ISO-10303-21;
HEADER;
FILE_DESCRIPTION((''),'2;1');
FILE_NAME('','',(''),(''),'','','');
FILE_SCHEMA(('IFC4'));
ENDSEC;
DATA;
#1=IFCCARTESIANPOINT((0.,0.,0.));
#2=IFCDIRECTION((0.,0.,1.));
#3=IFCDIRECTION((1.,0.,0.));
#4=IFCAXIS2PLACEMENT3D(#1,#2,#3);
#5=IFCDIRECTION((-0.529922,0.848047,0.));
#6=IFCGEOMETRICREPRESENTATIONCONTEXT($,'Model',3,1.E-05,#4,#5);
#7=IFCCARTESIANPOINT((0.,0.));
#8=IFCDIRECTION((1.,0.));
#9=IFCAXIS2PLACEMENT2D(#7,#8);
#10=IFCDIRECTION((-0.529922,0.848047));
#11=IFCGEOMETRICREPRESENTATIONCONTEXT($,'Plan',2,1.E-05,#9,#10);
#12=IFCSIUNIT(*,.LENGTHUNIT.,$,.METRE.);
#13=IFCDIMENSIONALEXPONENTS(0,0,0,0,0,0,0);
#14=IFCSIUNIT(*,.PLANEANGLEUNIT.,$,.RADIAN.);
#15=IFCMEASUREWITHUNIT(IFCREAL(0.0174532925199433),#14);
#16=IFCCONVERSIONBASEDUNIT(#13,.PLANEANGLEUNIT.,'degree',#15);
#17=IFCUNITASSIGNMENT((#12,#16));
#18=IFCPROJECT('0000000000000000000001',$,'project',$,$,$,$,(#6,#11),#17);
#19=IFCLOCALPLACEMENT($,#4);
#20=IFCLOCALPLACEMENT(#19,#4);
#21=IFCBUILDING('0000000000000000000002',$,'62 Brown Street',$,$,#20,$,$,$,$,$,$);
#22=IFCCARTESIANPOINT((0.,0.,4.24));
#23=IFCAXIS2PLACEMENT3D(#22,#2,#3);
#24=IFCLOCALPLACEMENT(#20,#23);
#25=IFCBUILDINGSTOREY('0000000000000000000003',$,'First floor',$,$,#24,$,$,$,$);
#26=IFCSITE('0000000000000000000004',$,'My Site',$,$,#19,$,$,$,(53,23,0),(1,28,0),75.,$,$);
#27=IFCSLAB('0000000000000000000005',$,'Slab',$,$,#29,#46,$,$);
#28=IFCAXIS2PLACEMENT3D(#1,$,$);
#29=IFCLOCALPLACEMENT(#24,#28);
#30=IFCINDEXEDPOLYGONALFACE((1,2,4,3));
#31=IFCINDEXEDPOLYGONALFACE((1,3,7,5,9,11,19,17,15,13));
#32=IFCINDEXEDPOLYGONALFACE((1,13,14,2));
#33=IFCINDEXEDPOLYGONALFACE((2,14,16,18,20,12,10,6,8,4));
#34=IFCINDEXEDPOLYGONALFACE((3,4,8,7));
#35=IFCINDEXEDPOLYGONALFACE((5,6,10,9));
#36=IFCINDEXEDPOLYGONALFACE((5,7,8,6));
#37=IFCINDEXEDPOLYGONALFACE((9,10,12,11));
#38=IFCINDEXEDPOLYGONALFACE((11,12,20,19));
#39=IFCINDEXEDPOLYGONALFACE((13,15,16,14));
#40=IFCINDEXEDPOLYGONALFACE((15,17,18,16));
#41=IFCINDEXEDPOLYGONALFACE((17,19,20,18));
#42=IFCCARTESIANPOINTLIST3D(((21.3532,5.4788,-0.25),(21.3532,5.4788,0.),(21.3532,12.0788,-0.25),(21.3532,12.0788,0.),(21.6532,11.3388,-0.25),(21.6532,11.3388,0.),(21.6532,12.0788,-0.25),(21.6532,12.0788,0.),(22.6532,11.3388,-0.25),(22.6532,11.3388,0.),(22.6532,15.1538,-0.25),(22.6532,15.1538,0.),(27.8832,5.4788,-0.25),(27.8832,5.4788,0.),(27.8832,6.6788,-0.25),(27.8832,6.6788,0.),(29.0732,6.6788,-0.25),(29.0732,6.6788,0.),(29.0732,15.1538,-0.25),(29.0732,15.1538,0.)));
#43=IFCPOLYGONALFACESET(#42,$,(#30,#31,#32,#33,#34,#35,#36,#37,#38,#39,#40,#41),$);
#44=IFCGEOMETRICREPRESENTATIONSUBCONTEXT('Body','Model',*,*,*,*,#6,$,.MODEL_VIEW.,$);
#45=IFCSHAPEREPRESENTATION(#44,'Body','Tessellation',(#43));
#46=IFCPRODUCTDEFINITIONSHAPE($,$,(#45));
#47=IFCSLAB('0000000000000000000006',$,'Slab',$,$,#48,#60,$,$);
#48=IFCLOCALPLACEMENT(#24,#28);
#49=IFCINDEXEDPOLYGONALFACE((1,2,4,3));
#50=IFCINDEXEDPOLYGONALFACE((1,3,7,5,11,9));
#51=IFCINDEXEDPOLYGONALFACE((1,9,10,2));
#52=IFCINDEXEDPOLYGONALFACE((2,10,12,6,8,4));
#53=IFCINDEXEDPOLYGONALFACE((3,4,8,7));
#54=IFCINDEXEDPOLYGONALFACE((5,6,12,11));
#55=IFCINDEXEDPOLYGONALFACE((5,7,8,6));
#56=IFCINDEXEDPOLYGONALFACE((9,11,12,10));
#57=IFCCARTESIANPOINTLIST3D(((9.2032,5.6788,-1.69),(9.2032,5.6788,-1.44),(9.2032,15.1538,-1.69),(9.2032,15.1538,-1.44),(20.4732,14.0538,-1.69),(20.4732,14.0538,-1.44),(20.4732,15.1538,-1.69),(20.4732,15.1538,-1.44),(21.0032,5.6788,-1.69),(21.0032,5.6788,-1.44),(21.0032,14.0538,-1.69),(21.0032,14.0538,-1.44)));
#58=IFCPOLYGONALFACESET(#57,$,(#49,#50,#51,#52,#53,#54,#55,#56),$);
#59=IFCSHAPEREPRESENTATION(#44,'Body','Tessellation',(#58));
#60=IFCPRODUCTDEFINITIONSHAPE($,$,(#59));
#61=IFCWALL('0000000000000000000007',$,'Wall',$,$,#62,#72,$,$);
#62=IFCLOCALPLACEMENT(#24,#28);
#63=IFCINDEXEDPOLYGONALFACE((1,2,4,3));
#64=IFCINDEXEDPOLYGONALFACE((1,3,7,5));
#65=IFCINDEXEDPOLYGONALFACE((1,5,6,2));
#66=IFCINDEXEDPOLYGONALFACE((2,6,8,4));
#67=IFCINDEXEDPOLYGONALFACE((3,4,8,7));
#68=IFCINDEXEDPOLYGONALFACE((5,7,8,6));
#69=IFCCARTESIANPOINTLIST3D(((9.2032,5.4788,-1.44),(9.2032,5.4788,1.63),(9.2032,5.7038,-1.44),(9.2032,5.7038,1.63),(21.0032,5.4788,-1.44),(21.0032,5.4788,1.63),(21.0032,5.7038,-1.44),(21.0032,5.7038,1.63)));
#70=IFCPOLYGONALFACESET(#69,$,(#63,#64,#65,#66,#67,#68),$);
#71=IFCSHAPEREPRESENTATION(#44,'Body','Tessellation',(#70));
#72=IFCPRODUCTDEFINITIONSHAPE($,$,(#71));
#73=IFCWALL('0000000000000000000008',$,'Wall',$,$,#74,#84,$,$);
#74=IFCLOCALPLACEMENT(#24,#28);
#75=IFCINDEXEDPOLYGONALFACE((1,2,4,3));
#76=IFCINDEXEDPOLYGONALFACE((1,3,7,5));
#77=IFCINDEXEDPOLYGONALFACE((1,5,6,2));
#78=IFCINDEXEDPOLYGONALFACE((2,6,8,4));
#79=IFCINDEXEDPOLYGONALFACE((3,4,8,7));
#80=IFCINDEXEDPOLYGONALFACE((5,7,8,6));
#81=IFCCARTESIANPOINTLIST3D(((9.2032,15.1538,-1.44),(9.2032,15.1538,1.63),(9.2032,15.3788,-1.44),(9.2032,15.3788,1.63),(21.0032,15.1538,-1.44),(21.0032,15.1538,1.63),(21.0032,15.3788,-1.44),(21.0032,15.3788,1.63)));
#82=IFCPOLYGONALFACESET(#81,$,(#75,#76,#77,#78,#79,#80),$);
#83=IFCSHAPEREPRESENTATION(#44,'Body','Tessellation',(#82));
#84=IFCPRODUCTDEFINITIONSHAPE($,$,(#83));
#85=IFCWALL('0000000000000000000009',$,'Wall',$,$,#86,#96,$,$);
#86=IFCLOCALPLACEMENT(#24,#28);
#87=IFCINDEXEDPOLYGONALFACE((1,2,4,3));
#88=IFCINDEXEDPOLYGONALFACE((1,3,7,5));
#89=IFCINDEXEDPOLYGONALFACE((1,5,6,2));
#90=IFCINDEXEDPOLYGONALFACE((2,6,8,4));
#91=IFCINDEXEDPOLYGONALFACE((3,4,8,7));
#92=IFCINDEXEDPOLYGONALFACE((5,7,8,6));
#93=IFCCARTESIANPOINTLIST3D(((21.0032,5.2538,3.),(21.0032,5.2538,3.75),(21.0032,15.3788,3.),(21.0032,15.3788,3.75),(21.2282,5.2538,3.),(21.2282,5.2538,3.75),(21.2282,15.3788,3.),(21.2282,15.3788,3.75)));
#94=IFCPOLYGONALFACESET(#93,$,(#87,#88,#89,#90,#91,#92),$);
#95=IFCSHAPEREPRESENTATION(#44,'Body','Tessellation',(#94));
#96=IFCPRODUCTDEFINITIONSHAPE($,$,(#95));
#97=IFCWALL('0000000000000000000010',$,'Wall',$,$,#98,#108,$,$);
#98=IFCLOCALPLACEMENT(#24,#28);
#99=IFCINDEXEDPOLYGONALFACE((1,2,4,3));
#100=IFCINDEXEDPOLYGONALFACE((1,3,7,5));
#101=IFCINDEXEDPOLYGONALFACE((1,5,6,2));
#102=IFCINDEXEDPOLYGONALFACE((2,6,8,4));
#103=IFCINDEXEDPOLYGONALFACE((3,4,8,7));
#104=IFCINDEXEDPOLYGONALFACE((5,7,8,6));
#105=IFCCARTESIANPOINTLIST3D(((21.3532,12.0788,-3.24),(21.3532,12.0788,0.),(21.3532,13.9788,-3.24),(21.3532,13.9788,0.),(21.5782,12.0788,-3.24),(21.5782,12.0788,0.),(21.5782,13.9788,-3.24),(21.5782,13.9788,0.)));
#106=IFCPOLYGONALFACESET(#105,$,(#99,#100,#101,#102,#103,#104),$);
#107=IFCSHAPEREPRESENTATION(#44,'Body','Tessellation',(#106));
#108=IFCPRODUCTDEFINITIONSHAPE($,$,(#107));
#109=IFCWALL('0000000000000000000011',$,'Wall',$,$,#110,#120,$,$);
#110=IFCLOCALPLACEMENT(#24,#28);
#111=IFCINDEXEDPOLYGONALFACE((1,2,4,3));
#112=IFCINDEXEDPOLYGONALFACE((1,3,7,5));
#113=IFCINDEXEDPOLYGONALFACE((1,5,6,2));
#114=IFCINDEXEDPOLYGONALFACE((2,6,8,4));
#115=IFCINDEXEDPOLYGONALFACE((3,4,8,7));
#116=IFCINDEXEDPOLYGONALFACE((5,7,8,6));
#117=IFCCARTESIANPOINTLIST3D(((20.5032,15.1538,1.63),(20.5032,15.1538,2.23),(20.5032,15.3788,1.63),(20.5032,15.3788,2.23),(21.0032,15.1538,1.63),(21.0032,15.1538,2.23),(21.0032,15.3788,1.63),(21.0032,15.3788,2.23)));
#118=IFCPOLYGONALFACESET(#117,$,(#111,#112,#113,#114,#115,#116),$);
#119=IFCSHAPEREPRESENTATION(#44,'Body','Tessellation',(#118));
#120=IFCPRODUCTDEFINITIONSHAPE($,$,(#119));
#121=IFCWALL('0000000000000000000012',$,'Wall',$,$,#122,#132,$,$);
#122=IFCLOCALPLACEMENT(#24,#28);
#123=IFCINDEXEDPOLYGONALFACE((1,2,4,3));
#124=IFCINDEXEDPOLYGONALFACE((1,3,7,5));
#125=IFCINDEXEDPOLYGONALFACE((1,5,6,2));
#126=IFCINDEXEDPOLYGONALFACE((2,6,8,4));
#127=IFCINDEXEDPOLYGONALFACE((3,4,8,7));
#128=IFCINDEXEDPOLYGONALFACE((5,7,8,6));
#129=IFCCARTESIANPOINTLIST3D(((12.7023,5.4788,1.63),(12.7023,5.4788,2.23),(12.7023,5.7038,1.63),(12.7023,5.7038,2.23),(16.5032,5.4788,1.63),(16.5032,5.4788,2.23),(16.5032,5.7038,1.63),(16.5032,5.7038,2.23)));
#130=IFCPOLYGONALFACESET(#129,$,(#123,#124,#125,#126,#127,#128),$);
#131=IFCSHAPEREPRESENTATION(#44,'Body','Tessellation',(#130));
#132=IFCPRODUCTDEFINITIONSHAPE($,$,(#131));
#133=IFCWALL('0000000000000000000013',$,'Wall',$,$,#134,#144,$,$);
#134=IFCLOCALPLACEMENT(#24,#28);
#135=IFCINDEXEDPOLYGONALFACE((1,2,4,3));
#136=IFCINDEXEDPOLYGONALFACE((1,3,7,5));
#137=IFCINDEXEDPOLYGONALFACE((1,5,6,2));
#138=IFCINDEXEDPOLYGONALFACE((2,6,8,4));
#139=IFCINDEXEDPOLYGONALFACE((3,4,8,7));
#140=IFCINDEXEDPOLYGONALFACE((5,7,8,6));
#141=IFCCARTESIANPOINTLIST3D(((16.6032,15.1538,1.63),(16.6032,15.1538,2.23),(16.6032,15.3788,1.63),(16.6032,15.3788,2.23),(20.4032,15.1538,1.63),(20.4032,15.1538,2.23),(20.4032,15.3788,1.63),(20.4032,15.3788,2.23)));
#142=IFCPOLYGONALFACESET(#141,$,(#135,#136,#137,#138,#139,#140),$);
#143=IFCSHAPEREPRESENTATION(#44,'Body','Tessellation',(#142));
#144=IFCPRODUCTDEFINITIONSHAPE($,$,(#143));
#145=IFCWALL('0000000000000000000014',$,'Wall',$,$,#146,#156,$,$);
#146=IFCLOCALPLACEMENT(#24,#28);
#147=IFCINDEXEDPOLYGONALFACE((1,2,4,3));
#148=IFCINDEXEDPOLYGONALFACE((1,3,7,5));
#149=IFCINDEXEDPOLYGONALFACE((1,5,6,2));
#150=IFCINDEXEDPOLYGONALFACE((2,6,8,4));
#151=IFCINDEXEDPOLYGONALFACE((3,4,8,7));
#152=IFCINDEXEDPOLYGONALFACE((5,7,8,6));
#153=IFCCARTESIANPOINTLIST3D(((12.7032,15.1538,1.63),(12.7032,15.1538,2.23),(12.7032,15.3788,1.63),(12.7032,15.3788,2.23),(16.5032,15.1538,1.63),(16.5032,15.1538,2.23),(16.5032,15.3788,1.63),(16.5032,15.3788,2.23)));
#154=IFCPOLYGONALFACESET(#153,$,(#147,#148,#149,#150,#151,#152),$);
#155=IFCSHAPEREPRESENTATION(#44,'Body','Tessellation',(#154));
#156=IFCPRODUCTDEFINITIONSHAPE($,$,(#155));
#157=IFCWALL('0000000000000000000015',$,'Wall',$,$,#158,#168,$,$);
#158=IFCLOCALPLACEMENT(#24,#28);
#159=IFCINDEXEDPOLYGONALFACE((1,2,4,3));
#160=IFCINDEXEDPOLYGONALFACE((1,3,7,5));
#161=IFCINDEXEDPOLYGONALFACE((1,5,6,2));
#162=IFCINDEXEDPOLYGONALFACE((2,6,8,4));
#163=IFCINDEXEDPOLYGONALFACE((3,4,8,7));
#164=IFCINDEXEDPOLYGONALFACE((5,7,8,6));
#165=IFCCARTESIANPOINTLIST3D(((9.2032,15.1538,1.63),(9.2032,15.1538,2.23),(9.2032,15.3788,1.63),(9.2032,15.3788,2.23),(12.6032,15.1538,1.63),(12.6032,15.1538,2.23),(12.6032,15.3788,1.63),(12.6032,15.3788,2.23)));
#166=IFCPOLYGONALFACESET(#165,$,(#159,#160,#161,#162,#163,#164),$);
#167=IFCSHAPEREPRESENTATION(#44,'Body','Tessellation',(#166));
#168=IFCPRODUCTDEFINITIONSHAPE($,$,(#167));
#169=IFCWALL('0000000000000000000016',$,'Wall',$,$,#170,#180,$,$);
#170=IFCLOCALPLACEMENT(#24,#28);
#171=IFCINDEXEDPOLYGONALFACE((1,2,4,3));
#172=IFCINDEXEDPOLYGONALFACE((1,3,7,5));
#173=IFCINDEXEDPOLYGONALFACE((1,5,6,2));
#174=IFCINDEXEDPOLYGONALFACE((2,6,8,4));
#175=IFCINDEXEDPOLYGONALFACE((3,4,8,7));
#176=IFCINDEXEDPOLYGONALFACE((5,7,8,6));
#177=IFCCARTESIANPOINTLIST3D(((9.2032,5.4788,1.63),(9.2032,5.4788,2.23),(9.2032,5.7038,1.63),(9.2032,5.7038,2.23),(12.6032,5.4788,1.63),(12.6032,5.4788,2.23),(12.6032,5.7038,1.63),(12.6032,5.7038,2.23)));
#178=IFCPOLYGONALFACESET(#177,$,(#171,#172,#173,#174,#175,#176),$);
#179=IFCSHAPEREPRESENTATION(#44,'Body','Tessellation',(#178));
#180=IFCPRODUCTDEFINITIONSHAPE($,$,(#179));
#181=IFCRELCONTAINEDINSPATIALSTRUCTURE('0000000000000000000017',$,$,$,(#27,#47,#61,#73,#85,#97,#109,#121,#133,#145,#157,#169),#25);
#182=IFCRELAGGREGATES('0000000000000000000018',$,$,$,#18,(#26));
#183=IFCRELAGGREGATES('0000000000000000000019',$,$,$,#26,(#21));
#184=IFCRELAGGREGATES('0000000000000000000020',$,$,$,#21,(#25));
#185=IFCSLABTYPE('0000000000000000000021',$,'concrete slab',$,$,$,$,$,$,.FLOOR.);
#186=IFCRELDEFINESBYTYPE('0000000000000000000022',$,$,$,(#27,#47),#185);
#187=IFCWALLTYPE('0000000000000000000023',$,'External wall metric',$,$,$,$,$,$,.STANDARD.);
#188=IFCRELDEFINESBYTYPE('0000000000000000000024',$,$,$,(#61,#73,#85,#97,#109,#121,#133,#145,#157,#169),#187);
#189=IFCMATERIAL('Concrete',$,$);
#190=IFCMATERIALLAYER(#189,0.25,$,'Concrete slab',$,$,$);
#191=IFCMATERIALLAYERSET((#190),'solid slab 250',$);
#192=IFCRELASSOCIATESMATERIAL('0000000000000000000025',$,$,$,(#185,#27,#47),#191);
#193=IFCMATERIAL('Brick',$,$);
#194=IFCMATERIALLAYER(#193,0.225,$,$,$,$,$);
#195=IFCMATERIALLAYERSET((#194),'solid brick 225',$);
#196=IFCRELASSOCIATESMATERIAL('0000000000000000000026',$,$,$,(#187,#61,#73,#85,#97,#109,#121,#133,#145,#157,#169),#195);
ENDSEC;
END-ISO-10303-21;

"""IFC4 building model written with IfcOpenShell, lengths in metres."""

from ifc_helpers import new_model, entity, si_unit, converted_unit, direction, frame, origin_with_axes, origin_2d_with_axis, place, context, subcontext, project, spatial, line, indexed_curve, outline, extrude, material, layer, layer_set, layer_usage, type_object, element, save


model = new_model("IFC4")

# Units and contexts
model_context = context("Model", 3, precision=1e-05, world=origin_with_axes(), true_north=direction((-0.529922, 0.848047, 0.0)))
plan_context = context("Plan", 2, precision=1e-05, world=origin_2d_with_axis(), true_north=direction((-0.529922, 0.848047)))
body_context_1 = subcontext(model_context, "Body", "Model", "MODEL_VIEW")
ifc_project = project(units=[si_unit("LENGTHUNIT", "METRE"), converted_unit("PLANEANGLEUNIT", "degree", entity("IfcReal", 0.0174532925199433), si_unit("PLANEANGLEUNIT", "RADIAN"), dimensions=[0, 0, 0, 0, 0, 0, 0])], contexts=[model_context, plan_context])

# Site, building, storey
site_placement = place(None, origin_with_axes())
site = spatial("IfcSite", under=ifc_project, at=site_placement, Name="My Site", RefLatitude=(53, 23, 0), RefLongitude=(1, 28, 0), RefElevation=75.0)
building_placement = place(site_placement, origin_with_axes())
building = spatial("IfcBuilding", under=site, at=building_placement, Name="62 Brown Street")
storey_placement = place(building_placement, frame((0.0, 0.0, 4.24), z_axis=(0.0, 0.0, 1.0), x_axis=(1.0, 0.0, 0.0)))
storey = spatial("IfcBuildingStorey", under=building, at=storey_placement, Name="First floor")

# Shared definitions
ifc_material_1 = material(Name="Concrete")

# Slabs
ifc_layer_1 = layer(ifc_material_1, 0.25, Name="Concrete slab")
ifc_layer_set_1 = layer_set([ifc_layer_1], Name="solid slab 250")
ifc_layer_usage_1 = layer_usage(ifc_layer_set_1, "AXIS3", "POSITIVE", 0.0)
slab_type = type_object("IfcSlabType", Name="concrete slab", PredefinedType="FLOOR", material=ifc_layer_set_1)
slab_1_placement = place(storey_placement, frame((21.3532, 5.4788, -0.25), z_axis=(0.0, 0.0, 1.0), x_axis=(1.0, 0.0, 0.0)))
element("IfcSlab", 1, at=slab_1_placement, inside=storey, type_object=slab_type, material=ifc_layer_usage_1, Name="Slab", context=body_context_1, shape_type="SweptSolid", body=[
    extrude(outline(indexed_curve([(6.53, 1.2), (6.53, 0.0), (0.0, 0.0), (0.0, 6.6), (0.3, 6.6), (0.3, 5.86), (1.3, 5.86), (1.3, 9.675), (7.72, 9.675), (7.72, 1.2), (6.53, 1.2)])), None, (0.0, 0.0, 1.0), 0.25),
])
ifc_layer_usage_2 = layer_usage(ifc_layer_set_1, "AXIS3", "POSITIVE", 0.0)
slab_2_placement = place(storey_placement, frame((9.2032, 5.6788, -1.69), z_axis=(0.0, 0.0, 1.0), x_axis=(1.0, 0.0, 0.0)))
element("IfcSlab", 2, at=slab_2_placement, inside=storey, type_object=slab_type, material=ifc_layer_usage_2, Name="Slab", context=body_context_1, shape_type="SweptSolid", body=[
    extrude(outline(indexed_curve([(11.27, 9.475), (11.8, 0.0), (0.0, 0.0), (0.0, 9.475), (11.8, 8.375), (11.27, 8.375)], segments=[line(6, 1), line(1, 4), line(4, 3), line(3, 2), line(2, 5), line(5, 6)], self_intersect=False)), None, (0.0, 0.0, 1.0), 0.25),
])

# Walls
ifc_material_2 = material(Name="Brick")
ifc_layer_2 = layer(ifc_material_2, 0.225)
ifc_layer_set_2 = layer_set([ifc_layer_2], Name="solid brick 225")
ifc_layer_usage_3 = layer_usage(ifc_layer_set_2, "AXIS2", "POSITIVE", 0.0)
wall_type_1 = type_object("IfcWallType", Name="External wall metric", PredefinedType="STANDARD", material=ifc_layer_set_2)
wall_1_placement = place(storey_placement, frame((9.2032, 5.4788, -1.44), z_axis=(0.0, 0.0, 1.0), x_axis=(1.0, 0.0, 0.0)))
element("IfcWall", 3, at=wall_1_placement, inside=storey, type_object=wall_type_1, material=ifc_layer_usage_3, Name="Wall", context=body_context_1, shape_type="SweptSolid", body=[
    extrude(outline(indexed_curve([(0.0, 0.0), (0.0, 0.225), (11.8, 0.225), (11.8, 0.0), (0.0, 0.0)], self_intersect=False)), origin_with_axes(), (0.0, 0.0, 1.0), 3.07),
])
ifc_layer_usage_4 = layer_usage(ifc_layer_set_2, "AXIS2", "POSITIVE", 0.0)
wall_2_placement = place(storey_placement, frame((21.0032, 15.3788, -1.44), z_axis=(0.0, 0.0, 1.0), x_axis=(-1.0, 0.0, 0.0)))
element("IfcWall", 4, at=wall_2_placement, inside=storey, type_object=wall_type_1, material=ifc_layer_usage_4, Name="Wall", context=body_context_1, shape_type="SweptSolid", body=[
    extrude(outline(indexed_curve([(0.0, 0.0), (0.0, 0.225), (11.8, 0.225), (11.8, 0.0), (0.0, 0.0)], self_intersect=False)), origin_with_axes(), (0.0, 0.0, 1.0), 3.07),
])
ifc_layer_usage_5 = layer_usage(ifc_layer_set_2, "AXIS2", "POSITIVE", 0.0)
wall_3_placement = place(storey_placement, frame((21.0032, 15.3788, 3.0), z_axis=(0.0, 0.0, 1.0), x_axis=(0.0, -1.0, 0.0)))
element("IfcWall", 5, at=wall_3_placement, inside=storey, type_object=wall_type_1, material=ifc_layer_usage_5, Name="Wall", context=body_context_1, shape_type="SweptSolid", body=[
    extrude(outline(indexed_curve([(0.0, 0.0), (0.0, 0.225), (10.125, 0.225), (10.125, 0.0), (0.0, 0.0)], self_intersect=False)), origin_with_axes(), (0.0, 0.0, 1.0), 0.75),
])
ifc_layer_usage_6 = layer_usage(ifc_layer_set_2, "AXIS2", "POSITIVE", 0.0)
wall_4_placement = place(storey_placement, frame((21.3532, 13.9788, -3.24), z_axis=(0.0, 0.0, 1.0), x_axis=(0.0, -1.0, 0.0)))
element("IfcWall", 6, at=wall_4_placement, inside=storey, type_object=wall_type_1, material=ifc_layer_usage_6, Name="Wall", context=body_context_1, shape_type="SweptSolid", body=[
    extrude(outline(indexed_curve([(0.0, 0.0), (0.0, 0.225), (1.9, 0.225), (1.9, 0.0), (0.0, 0.0)], self_intersect=False)), origin_with_axes(), (0.0, 0.0, 1.0), 3.24),
])
ifc_layer_usage_7 = layer_usage(ifc_layer_set_2, "AXIS2", "POSITIVE", 0.0)
wall_5_placement = place(storey_placement, frame((21.0032, 15.3788, 1.63), z_axis=(0.0, 0.0, 1.0), x_axis=(-1.0, 0.0, 0.0)))
element("IfcWall", 7, at=wall_5_placement, inside=storey, type_object=wall_type_1, material=ifc_layer_usage_7, Name="Wall", context=body_context_1, shape_type="SweptSolid", body=[
    extrude(outline(indexed_curve([(0.0, 0.0), (0.0, 0.225), (0.5, 0.225), (0.5, 0.0), (0.0, 0.0)], self_intersect=False)), origin_with_axes(), (0.0, 0.0, 1.0), 0.6),
])
ifc_layer_usage_8 = layer_usage(ifc_layer_set_2, "AXIS2", "POSITIVE", 0.0)
wall_6_placement = place(storey_placement, frame((12.7023, 5.4788, 1.63), z_axis=(0.0, 0.0, 1.0), x_axis=(1.0, 0.0, 0.0)))
element("IfcWall", 8, at=wall_6_placement, inside=storey, type_object=wall_type_1, material=ifc_layer_usage_8, Name="Wall", context=body_context_1, shape_type="SweptSolid", body=[
    extrude(outline(indexed_curve([(0.0, 0.0), (0.0, 0.225), (3.8009, 0.225), (3.8009, 0.0), (0.0, 0.0)], self_intersect=False)), origin_with_axes(), (0.0, 0.0, 1.0), 0.6),
])
ifc_layer_usage_9 = layer_usage(ifc_layer_set_2, "AXIS2", "POSITIVE", 0.0)
wall_7_placement = place(storey_placement, frame((20.4032, 15.3788, 1.63), z_axis=(0.0, 0.0, 1.0), x_axis=(-1.0, 0.0, 0.0)))
element("IfcWall", 9, at=wall_7_placement, inside=storey, type_object=wall_type_1, material=ifc_layer_usage_9, Name="Wall", context=body_context_1, shape_type="SweptSolid", body=[
    extrude(outline(indexed_curve([(0.0, 0.0), (0.0, 0.225), (3.8, 0.225), (3.8, 0.0), (0.0, 0.0)], self_intersect=False)), origin_with_axes(), (0.0, 0.0, 1.0), 0.6),
])
ifc_layer_usage_10 = layer_usage(ifc_layer_set_2, "AXIS2", "POSITIVE", 0.0)
wall_8_placement = place(storey_placement, frame((16.5032, 15.3788, 1.63), z_axis=(0.0, 0.0, 1.0), x_axis=(-1.0, 0.0, 0.0)))
element("IfcWall", 10, at=wall_8_placement, inside=storey, type_object=wall_type_1, material=ifc_layer_usage_10, Name="Wall", context=body_context_1, shape_type="SweptSolid", body=[
    extrude(outline(indexed_curve([(0.0, 0.0), (0.0, 0.225), (3.8, 0.225), (3.8, 0.0), (0.0, 0.0)], self_intersect=False)), origin_with_axes(), (0.0, 0.0, 1.0), 0.6),
])
ifc_layer_usage_11 = layer_usage(ifc_layer_set_2, "AXIS2", "POSITIVE", 0.0)
wall_9_placement = place(storey_placement, frame((12.6032, 15.3788, 1.63), z_axis=(0.0, 0.0, 1.0), x_axis=(-1.0, 0.0, 0.0)))
element("IfcWall", 11, at=wall_9_placement, inside=storey, type_object=wall_type_1, material=ifc_layer_usage_11, Name="Wall", context=body_context_1, shape_type="SweptSolid", body=[
    extrude(outline(indexed_curve([(0.0, 0.0), (0.0, 0.225), (3.4, 0.225), (3.4, 0.0), (0.0, 0.0)], self_intersect=False)), origin_with_axes(), (0.0, 0.0, 1.0), 0.6),
])
ifc_layer_usage_12 = layer_usage(ifc_layer_set_2, "AXIS2", "POSITIVE", 0.0)
wall_10_placement = place(storey_placement, frame((9.2032, 5.4788, 1.63), z_axis=(0.0, 0.0, 1.0), x_axis=(1.0, 0.0, 0.0)))
element("IfcWall", 12, at=wall_10_placement, inside=storey, type_object=wall_type_1, material=ifc_layer_usage_12, Name="Wall", context=body_context_1, shape_type="SweptSolid", body=[
    extrude(outline(indexed_curve([(0.0, 0.0), (0.0, 0.225), (3.4, 0.225), (3.4, 0.0), (0.0, 0.0)], self_intersect=False)), origin_with_axes(), (0.0, 0.0, 1.0), 0.6),
])

save(model, "model.ifc")
